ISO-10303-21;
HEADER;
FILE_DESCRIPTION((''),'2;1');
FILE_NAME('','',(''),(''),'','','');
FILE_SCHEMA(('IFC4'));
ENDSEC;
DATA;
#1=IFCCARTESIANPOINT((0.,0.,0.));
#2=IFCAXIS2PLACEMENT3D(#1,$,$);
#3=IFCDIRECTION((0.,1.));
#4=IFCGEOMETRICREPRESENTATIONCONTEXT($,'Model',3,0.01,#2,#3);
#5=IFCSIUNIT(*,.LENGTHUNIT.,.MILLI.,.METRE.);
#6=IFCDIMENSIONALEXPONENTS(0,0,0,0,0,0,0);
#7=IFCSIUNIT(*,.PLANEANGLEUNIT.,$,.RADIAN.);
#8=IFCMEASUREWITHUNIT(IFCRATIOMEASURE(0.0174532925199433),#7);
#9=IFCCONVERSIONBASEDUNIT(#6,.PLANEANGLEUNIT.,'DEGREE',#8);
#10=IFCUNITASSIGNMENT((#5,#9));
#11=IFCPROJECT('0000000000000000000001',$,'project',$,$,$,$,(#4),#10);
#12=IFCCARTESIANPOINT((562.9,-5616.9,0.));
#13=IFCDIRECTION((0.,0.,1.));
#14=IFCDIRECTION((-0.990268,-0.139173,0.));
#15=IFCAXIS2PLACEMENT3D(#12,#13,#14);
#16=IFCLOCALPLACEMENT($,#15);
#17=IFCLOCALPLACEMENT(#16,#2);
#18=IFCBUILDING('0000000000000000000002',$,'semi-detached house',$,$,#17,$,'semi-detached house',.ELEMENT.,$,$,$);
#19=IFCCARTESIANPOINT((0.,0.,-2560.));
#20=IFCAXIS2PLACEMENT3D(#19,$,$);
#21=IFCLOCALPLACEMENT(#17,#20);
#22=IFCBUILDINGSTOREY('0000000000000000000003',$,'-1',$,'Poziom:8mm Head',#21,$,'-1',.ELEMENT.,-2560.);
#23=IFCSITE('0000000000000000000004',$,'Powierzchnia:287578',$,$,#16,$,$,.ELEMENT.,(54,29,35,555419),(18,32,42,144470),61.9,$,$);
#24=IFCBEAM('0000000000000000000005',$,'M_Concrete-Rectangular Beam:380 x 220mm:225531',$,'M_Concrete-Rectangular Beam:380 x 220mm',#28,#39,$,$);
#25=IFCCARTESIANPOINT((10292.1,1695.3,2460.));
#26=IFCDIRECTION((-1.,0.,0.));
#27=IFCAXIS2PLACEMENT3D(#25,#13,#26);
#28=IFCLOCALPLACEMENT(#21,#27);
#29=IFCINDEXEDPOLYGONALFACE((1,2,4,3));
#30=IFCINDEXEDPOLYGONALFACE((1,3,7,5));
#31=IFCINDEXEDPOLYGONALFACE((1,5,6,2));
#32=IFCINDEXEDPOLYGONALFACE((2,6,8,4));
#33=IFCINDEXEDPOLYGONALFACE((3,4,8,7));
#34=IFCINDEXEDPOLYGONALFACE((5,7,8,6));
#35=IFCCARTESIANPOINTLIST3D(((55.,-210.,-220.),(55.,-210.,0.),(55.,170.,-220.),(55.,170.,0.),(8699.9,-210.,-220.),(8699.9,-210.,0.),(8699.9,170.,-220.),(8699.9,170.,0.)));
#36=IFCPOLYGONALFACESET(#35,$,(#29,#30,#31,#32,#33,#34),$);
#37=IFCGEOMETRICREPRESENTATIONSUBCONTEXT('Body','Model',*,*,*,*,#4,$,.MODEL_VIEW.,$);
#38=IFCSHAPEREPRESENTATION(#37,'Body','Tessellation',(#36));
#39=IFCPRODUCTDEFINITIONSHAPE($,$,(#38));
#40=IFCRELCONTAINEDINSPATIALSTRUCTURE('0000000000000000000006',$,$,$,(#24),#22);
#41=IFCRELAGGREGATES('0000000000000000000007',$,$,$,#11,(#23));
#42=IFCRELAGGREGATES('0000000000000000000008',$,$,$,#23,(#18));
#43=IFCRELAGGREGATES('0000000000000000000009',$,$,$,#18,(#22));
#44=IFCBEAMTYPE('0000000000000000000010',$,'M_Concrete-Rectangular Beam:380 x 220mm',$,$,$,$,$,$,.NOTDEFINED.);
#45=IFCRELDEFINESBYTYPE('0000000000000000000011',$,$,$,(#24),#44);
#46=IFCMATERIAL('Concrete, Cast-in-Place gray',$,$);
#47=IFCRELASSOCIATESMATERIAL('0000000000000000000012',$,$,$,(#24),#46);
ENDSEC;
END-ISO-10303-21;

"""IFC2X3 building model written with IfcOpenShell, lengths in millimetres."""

from ifc_helpers import new_model, entity, si_unit, converted_unit, direction, frame, frame_2d, origin, place, context, subcontext, project, spatial, rectangle, extrude, material, type_object, element, save


model = new_model("IFC2X3")

# Units and contexts
model_context = context("Model", 3, precision=0.01, world=origin(), true_north=direction((0.0, 1.0)))
body_context = subcontext(model_context, "Body", "Model", "MODEL_VIEW")
ifc_project = project(units=[si_unit("LENGTHUNIT", "METRE", prefix="MILLI"), converted_unit("PLANEANGLEUNIT", "DEGREE", entity("IfcRatioMeasure", 0.0174532925199433), si_unit("PLANEANGLEUNIT", "RADIAN"), dimensions=[0, 0, 0, 0, 0, 0, 0])], contexts=[model_context])

# Site, building, storey
site_placement = place(None, frame((562.9, -5616.9, 0.0), z_axis=(0.0, 0.0, 1.0), x_axis=(-0.990268, -0.139173, 0.0)))
site = spatial("IfcSite", under=ifc_project, at=site_placement, Name="Powierzchnia:287578", CompositionType="ELEMENT", RefLatitude=(54, 29, 35, 555419), RefLongitude=(18, 32, 42, 144470), RefElevation=61.9)
building_placement = place(site_placement, origin())
building = spatial("IfcBuilding", under=site, at=building_placement, Name="semi-detached house", LongName="semi-detached house", CompositionType="ELEMENT")
storey_placement = place(building_placement, frame((0.0, 0.0, -2560.0)))
storey = spatial("IfcBuildingStorey", under=building, at=storey_placement, Name="-1", ObjectType="Poziom:8mm Head", LongName="-1", CompositionType="ELEMENT", Elevation=-2560.0)

# Beam
ifc_material_1 = material(Name="Concrete, Cast-in-Place gray")
beam_type_1 = type_object("IfcBeamType", Name="M_Concrete-Rectangular Beam:380 x 220mm", PredefinedType="NOTDEFINED")
beam_1_placement = place(storey_placement, frame((10292.1, 1695.3, 2460.0), z_axis=(0.0, 0.0, 1.0), x_axis=(-1.0, 0.0, 0.0)))
element("IfcBeam", 1, at=beam_1_placement, inside=storey, type_object=beam_type_1, material=ifc_material_1, Name="M_Concrete-Rectangular Beam:380 x 220mm:225531", ObjectType="M_Concrete-Rectangular Beam:380 x 220mm", context=body_context, shape_type="SweptSolid", body=[
    extrude(rectangle(XDim=220.0, YDim=380.0, at=frame_2d((0.0, 0.0), x_axis=(1.0, 0.0))), frame((55.0, -20.0, -110.0), z_axis=(1.0, 0.0, 0.0), x_axis=(0.0, 0.0, -1.0)), (0.0, 0.0, 1.0), 8644.9),
])

save(model, "model.ifc")
